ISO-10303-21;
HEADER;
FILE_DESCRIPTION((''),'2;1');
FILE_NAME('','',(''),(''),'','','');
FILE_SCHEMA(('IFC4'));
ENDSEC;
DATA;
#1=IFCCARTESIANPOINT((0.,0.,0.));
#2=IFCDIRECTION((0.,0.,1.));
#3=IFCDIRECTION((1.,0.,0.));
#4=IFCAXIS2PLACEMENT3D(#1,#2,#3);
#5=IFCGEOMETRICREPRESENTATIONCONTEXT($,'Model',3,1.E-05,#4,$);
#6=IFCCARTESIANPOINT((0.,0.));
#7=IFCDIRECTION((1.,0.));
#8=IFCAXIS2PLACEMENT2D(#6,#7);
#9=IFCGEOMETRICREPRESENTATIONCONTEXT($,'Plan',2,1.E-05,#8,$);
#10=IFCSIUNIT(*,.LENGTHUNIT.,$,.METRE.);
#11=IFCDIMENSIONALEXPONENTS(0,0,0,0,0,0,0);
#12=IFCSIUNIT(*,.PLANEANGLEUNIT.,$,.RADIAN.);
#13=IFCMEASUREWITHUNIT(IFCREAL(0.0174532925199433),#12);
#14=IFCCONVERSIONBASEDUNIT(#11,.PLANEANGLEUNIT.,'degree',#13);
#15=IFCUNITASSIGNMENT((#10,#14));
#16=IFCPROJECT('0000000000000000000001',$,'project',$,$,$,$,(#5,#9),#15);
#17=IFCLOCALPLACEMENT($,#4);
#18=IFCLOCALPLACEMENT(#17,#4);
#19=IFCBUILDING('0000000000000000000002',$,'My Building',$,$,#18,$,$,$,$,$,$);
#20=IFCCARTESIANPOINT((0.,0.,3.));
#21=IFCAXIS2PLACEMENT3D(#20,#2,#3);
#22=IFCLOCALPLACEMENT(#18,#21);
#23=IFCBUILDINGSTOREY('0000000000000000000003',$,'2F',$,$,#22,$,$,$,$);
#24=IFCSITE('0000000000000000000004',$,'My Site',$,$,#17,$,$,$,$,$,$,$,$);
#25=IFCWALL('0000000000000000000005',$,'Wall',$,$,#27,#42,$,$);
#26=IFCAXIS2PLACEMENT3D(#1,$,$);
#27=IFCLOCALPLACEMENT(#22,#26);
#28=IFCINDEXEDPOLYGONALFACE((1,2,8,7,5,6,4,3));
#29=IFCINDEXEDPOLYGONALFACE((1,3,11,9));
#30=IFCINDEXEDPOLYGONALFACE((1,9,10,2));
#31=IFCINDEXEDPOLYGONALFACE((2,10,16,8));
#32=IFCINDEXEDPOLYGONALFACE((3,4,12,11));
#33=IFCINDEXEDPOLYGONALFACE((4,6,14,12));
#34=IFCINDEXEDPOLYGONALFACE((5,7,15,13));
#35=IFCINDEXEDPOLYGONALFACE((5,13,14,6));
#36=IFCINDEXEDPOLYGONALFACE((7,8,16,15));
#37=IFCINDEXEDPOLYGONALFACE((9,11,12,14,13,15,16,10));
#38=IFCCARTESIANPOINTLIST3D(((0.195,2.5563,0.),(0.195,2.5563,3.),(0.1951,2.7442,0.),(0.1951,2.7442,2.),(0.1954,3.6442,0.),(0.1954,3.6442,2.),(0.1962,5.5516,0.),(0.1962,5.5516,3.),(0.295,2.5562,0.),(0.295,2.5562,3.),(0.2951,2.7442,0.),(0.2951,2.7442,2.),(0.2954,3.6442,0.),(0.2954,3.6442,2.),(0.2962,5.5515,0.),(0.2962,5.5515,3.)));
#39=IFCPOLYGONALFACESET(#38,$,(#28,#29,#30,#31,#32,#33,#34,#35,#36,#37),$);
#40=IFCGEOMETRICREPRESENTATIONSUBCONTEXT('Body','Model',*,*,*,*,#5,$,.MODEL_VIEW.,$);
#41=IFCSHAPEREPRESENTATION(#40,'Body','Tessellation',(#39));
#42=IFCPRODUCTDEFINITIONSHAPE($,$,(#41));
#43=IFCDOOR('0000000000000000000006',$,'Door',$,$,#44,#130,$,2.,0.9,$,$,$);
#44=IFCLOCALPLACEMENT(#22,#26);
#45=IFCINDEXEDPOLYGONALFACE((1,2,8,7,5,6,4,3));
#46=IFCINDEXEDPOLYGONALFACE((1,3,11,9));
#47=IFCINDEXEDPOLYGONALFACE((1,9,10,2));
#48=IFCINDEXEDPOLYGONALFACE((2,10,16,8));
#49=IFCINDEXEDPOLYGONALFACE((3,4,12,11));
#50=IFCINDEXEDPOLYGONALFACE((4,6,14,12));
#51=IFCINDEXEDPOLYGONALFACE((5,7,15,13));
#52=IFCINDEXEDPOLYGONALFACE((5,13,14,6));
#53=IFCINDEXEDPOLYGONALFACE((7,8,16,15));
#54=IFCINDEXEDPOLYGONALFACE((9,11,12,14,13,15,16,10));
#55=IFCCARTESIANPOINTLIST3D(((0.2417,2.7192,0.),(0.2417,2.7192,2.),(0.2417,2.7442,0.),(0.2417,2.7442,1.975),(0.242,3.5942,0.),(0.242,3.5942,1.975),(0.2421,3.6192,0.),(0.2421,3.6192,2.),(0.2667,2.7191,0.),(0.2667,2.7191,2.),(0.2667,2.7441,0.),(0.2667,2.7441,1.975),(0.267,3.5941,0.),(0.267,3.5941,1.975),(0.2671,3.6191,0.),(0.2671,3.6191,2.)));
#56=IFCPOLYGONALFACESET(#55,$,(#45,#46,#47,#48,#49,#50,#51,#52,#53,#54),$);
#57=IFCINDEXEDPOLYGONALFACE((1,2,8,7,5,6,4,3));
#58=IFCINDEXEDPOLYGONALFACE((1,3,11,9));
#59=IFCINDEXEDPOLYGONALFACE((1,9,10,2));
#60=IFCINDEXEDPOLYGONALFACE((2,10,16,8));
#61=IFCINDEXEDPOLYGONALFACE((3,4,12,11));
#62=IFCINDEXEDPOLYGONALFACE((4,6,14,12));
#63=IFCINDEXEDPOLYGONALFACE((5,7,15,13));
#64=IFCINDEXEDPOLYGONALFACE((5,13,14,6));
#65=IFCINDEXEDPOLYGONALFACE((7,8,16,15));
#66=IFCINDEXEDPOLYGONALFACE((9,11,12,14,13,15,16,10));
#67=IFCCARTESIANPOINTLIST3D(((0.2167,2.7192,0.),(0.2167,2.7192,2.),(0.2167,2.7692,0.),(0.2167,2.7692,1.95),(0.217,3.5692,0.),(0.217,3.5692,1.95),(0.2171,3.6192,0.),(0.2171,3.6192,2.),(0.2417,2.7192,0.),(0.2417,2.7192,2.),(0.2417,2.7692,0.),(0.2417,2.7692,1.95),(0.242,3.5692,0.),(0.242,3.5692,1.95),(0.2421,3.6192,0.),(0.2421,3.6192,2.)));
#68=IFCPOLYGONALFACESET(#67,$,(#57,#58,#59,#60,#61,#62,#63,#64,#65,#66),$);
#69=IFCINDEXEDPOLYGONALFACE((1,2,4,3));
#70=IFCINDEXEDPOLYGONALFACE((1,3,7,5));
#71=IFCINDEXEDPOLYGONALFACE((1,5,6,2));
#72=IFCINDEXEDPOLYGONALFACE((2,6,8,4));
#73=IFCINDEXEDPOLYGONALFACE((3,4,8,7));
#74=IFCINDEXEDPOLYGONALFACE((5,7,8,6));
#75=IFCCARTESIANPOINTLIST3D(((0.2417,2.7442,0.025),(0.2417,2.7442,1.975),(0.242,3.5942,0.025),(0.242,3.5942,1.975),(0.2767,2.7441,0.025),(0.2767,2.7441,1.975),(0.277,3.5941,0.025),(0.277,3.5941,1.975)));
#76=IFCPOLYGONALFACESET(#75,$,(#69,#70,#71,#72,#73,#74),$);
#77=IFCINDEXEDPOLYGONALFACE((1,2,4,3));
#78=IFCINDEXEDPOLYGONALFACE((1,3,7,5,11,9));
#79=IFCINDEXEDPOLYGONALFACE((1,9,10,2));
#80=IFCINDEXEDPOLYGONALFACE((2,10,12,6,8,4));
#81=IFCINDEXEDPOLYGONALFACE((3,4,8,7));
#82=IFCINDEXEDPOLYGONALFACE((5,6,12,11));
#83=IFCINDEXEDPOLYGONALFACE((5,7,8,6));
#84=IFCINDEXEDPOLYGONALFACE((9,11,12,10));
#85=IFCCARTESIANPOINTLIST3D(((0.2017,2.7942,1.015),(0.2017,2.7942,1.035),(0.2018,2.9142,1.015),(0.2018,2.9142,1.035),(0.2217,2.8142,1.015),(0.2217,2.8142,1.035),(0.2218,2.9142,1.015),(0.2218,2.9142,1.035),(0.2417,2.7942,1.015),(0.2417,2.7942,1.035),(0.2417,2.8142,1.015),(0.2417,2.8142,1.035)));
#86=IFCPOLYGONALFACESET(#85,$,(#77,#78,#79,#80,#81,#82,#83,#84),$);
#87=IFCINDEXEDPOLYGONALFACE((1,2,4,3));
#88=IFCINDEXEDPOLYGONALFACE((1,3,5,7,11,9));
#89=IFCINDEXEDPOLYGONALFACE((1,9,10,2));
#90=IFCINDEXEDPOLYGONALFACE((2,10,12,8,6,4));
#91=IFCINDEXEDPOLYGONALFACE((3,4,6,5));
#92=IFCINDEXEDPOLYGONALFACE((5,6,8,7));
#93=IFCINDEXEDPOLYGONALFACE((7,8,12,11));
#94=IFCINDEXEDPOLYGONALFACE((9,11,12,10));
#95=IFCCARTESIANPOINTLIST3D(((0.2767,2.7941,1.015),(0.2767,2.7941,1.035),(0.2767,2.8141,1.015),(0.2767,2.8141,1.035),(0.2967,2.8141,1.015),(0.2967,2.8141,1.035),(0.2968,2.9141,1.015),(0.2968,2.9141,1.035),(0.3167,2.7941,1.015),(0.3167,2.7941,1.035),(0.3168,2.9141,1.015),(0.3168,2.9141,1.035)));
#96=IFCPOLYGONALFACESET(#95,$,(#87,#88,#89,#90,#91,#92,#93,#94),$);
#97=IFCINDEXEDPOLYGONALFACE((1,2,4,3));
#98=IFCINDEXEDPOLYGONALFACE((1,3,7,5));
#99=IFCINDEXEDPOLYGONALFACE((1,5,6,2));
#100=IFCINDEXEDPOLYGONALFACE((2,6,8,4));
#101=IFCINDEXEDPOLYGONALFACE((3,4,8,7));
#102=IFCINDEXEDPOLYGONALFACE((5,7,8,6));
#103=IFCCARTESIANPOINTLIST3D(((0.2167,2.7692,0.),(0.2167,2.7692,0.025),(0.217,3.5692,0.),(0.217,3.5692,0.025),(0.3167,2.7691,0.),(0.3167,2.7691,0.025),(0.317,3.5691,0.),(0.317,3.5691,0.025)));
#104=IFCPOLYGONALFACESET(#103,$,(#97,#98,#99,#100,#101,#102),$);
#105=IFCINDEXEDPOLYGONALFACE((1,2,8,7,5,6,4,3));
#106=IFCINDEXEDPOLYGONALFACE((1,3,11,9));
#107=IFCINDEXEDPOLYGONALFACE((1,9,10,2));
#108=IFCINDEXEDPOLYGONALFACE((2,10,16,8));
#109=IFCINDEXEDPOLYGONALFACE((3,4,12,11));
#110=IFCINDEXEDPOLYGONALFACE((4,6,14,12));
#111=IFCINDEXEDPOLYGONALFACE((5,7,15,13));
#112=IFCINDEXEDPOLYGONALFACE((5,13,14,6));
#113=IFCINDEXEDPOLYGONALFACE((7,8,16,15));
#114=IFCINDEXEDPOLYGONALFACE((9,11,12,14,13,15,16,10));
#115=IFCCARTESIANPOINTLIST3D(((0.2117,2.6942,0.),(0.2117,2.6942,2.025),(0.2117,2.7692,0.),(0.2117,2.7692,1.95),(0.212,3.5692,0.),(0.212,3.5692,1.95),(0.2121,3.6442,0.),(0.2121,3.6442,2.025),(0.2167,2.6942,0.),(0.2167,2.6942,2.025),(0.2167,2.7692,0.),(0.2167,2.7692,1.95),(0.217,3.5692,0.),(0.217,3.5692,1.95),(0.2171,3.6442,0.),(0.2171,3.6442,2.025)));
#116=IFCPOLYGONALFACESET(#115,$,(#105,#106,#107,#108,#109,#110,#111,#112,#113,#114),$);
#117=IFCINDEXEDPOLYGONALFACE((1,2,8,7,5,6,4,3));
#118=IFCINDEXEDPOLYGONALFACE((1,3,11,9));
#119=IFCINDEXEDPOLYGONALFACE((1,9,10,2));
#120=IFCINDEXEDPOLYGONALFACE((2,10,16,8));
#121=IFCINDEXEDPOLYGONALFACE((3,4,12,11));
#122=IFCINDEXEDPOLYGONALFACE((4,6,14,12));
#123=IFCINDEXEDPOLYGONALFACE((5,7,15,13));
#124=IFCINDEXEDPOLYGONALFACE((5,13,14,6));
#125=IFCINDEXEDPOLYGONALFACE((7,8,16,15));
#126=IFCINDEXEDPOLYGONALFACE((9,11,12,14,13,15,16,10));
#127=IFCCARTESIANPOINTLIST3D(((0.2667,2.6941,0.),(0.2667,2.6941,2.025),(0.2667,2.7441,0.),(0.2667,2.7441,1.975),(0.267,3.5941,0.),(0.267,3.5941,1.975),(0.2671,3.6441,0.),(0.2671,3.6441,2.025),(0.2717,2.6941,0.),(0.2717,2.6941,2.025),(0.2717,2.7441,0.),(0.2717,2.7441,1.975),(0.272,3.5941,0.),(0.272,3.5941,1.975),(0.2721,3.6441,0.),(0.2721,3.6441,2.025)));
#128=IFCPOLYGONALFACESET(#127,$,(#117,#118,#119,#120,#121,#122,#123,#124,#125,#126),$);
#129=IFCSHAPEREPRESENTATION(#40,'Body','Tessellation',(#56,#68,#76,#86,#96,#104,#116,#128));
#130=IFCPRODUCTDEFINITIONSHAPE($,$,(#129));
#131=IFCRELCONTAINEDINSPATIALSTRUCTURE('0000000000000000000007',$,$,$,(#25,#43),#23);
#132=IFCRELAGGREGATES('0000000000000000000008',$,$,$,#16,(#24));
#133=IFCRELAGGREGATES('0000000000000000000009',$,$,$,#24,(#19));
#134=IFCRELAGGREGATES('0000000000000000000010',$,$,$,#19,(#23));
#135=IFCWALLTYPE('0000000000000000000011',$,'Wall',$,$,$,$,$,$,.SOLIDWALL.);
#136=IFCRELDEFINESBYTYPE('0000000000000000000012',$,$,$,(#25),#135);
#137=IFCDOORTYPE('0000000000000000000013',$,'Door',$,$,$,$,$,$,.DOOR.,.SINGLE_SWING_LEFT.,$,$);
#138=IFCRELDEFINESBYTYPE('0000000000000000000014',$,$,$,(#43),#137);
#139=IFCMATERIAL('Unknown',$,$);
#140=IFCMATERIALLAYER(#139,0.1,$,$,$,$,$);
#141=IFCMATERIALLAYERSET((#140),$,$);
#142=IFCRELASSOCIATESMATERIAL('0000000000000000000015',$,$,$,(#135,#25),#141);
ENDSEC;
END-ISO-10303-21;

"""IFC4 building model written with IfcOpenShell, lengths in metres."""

from ifc_helpers import new_model, entity, si_unit, converted_unit, frame, origin_with_axes, origin_2d_with_axis, place, context, subcontext, project, spatial, line, indexed_curve, outline, extrude, shape, source, transform, mapped, material, layer, layer_set, layer_usage, type_object, type_shapes, element, fill, save


model = new_model("IFC4")

# Units and contexts
model_context = context("Model", 3, precision=1e-05, world=origin_with_axes())
plan_context = context("Plan", 2, precision=1e-05, world=origin_2d_with_axis())
body_context_1 = subcontext(model_context, "Body", "Model", "MODEL_VIEW")
body_context_2 = subcontext(plan_context, "Body", "Plan", "PLAN_VIEW")
ifc_project = project(units=[si_unit("LENGTHUNIT", "METRE"), converted_unit("PLANEANGLEUNIT", "degree", entity("IfcReal", 0.0174532925199433), si_unit("PLANEANGLEUNIT", "RADIAN"), dimensions=[0, 0, 0, 0, 0, 0, 0])], contexts=[model_context, plan_context])

# Site, building, storey
site_placement = place(None, origin_with_axes())
site = spatial("IfcSite", under=ifc_project, at=site_placement, Name="My Site")
building_placement = place(site_placement, origin_with_axes())
building = spatial("IfcBuilding", under=site, at=building_placement, Name="My Building")
storey_placement = place(building_placement, frame((0.0, 0.0, 3.0), z_axis=(0.0, 0.0, 1.0), x_axis=(1.0, 0.0, 0.0)))
storey = spatial("IfcBuildingStorey", under=building, at=storey_placement, Name="2F")

# Shared definitions
ifc_material = material(Name="Unknown")
ifc_layer = layer(ifc_material, 0.1)
ifc_layer_set = layer_set([ifc_layer])
wall_type = type_object("IfcWallType", Name="Wall", PredefinedType="SOLIDWALL", material=ifc_layer_set)

# Wall, opening, door
ifc_layer_usage_1 = layer_usage(ifc_layer_set, "AXIS2", "POSITIVE", 0.0)
wall_1_placement = place(storey_placement, frame((0.1962, 5.5516, 0.0), z_axis=(0.0, 0.0, 1.0), x_axis=(-0.000399, -1.0, 0.0)))
wall_1 = element("IfcWall", 1, at=wall_1_placement, inside=storey, type_object=wall_type, material=ifc_layer_usage_1, Name="Wall", context=body_context_1, shape_type="SweptSolid", body=[
    extrude(outline(indexed_curve([(0.0, 0.0), (0.0, 0.1), (2.9953, 0.1), (2.9953, 0.0)], segments=[line(1, 2, 3, 4, 1)])), origin_with_axes(), (0.0, 0.0, 1.0), 3.0),
])
shared_shape_1 = source(origin_with_axes(), body_context_1, "Body", "SweptSolid", [
    extrude(outline(indexed_curve([(0.0, 0.0), (0.9, 0.0), (0.9, 2.0), (0.0, 2.0)], segments=[line(1, 2, 3, 4, 1)])), frame((0.0, -0.6, 0.0), z_axis=(0.0, -1.0, 0.0), x_axis=(1.0, 0.0, 0.0)), (0.0, 0.0, -1.0), 1.2),
])
opening_1_placement = place(wall_1_placement, frame((1.9074, 0.0, 0.0), z_axis=(0.0, 0.0, 1.0), x_axis=(1.0, 0.0, 0.0)))
opening_1 = element("IfcOpeningElement", 2, at=opening_1_placement, cuts=wall_1, PredefinedType="OPENING", context=body_context_1, shape_type="MappedRepresentation", body=[
    mapped(shared_shape_1, transform((0.0, 0.0, 0.0), x_axis=(1.0, 0.0, 0.0), y_axis=(0.0, 1.0, 0.0), z_axis=(0.0, 0.0, 1.0), scale=1.0)),
])
door_type_1 = type_object("IfcDoorType", Name="Door", OperationType="SINGLE_SWING_LEFT", PredefinedType="DOOR")
shared_shape_2 = source(origin_with_axes(), body_context_1, "Body", "SweptSolid", [
    extrude(outline(indexed_curve([(0.0, 0.0), (0.0, 2.0), (0.9, 2.0), (0.9, 0.0), (0.875, 0.0), (0.875, 1.975), (0.025, 1.975), (0.025, 0.0)], segments=[line(1, 2, 3, 4, 5, 6, 7, 8, 1)])), frame((0.0, 0.025, 0.0), z_axis=(0.0, -1.0, 0.0), x_axis=(1.0, 0.0, 0.0)), (0.0, 0.0, -1.0), 0.025),
    extrude(outline(indexed_curve([(0.0, 0.0), (0.0, 2.0), (0.9, 2.0), (0.9, 0.0), (0.85, 0.0), (0.85, 1.95), (0.05, 1.95), (0.05, 0.0)], segments=[line(1, 2, 3, 4, 5, 6, 7, 8, 1)])), frame((0.0, 0.0, 0.0), z_axis=(0.0, -1.0, 0.0), x_axis=(1.0, 0.0, 0.0)), (0.0, 0.0, -1.0), 0.025),
    extrude(outline(indexed_curve([(0.0, 0.0), (0.85, 0.0), (0.85, 0.035), (0.0, 0.035)], segments=[line(1, 2, 3, 4, 1)])), frame((0.025, 0.025, 0.025), z_axis=(0.0, 0.0, 1.0), x_axis=(1.0, 0.0, 0.0)), (0.0, 0.0, 1.0), 1.95),
    extrude(outline(indexed_curve([(0.0, 0.0), (0.0, -0.04), (-0.12, -0.04), (-0.12, -0.02), (-0.02, -0.02), (-0.02, 0.0)], segments=[line(1, 2, 3, 4, 5, 6, 1)])), frame((0.825, 0.025, 1.015), z_axis=(0.0, 0.0, 1.0), x_axis=(1.0, 0.0, 0.0)), (0.0, 0.0, 1.0), 0.02),
    extrude(outline(indexed_curve([(0.0, 0.0), (0.0, 0.04), (-0.12, 0.04), (-0.12, 0.02), (-0.02, 0.02), (-0.02, 0.0)], segments=[line(1, 2, 3, 4, 5, 6, 1)])), frame((0.825, 0.06, 1.015), z_axis=(0.0, 0.0, 1.0), x_axis=(1.0, 0.0, 0.0)), (0.0, 0.0, 1.0), 0.02),
    extrude(outline(indexed_curve([(0.0, 0.0), (0.8, 0.0), (0.8, 0.1), (0.0, 0.1)], segments=[line(1, 2, 3, 4, 1)])), frame((0.05, 0.0, 0.0), z_axis=(0.0, 0.0, 1.0), x_axis=(1.0, 0.0, 0.0)), (0.0, 0.0, 1.0), 0.025),
    extrude(outline(indexed_curve([(0.0, 0.0), (0.0, 2.025), (0.95, 2.025), (0.95, 0.0), (0.875, 0.0), (0.875, 1.95), (0.075, 1.95), (0.075, 0.0)], segments=[line(1, 2, 3, 4, 5, 6, 7, 8, 1)])), frame((-0.025, -0.005, 0.0), z_axis=(0.0, -1.0, 0.0), x_axis=(1.0, 0.0, 0.0)), (0.0, 0.0, -1.0), 0.005),
    extrude(outline(indexed_curve([(0.0, 0.0), (0.0, 2.025), (0.95, 2.025), (0.95, 0.0), (0.9, 0.0), (0.9, 1.975), (0.05, 1.975), (0.05, 0.0)], segments=[line(1, 2, 3, 4, 5, 6, 7, 8, 1)])), frame((-0.025, 0.05, 0.0), z_axis=(0.0, -1.0, 0.0), x_axis=(1.0, 0.0, 0.0)), (0.0, 0.0, -1.0), 0.005),
])
shared_shape_3 = source(origin_with_axes(), body_context_2, "Body", "Curve2D", [
    entity("IfcIndexedPolyCurve", entity("IfcCartesianPointList2D", [[0.0, 0.0], [0.0, 0.05], [0.025, 0.05], [0.025, 0.025], [0.05, 0.025], [0.05, 0.0]]), [entity("IfcLineIndex", [1, 2, 3, 4, 5, 6, 1])]),
    entity("IfcIndexedPolyCurve", entity("IfcCartesianPointList2D", [[0.9, 0.0], [0.9, 0.05], [0.875, 0.05], [0.875, 0.025], [0.85, 0.025], [0.85, 0.0]]), [entity("IfcLineIndex", [1, 2, 3, 4, 5, 6, 1])]),
    entity("IfcTrimmedCurve", entity("IfcEllipse", entity("IfcAxis2Placement2D", entity("IfcCartesianPoint", [0.06, 0.05]), entity("IfcDirection", [1.0, 0.0])), 0.815, 0.85), [entity("IfcCartesianPoint", [0.875, 0.05])], [entity("IfcCartesianPoint", [0.06, 0.9])], True, "CARTESIAN"),
    entity("IfcIndexedPolyCurve", entity("IfcCartesianPointList2D", [[0.025, 0.05], [0.06, 0.05], [0.06, 0.9], [0.025, 0.9]]), [entity("IfcLineIndex", [1, 2, 3, 4, 1])]),
])
type_shapes(door_type_1, [shared_shape_2, shared_shape_3])
door_1_placement = place(opening_1_placement, frame((0.025, 0.0216, 0.0), z_axis=(0.0, 0.0, 1.0), x_axis=(1.0, 0.0, 0.0)))
door_1 = element("IfcDoor", 3, at=door_1_placement, inside=storey, type_object=door_type_1, Name="Door", OverallHeight=2.0, OverallWidth=0.9, shapes=[
    shape(body_context_1, "Body", "MappedRepresentation", [mapped(shared_shape_2, transform((0.0, 0.0, 0.0), x_axis=(1.0, 0.0, 0.0), y_axis=(0.0, 1.0, 0.0), z_axis=(0.0, 0.0, 1.0), scale=1.0))]),
    shape(body_context_2, "Body", "MappedRepresentation", [mapped(shared_shape_3, transform((0.0, 0.0, 0.0), x_axis=(1.0, 0.0, 0.0), y_axis=(0.0, 1.0, 0.0), z_axis=(0.0, 0.0, 1.0), scale=1.0))]),
])
fill(opening_1, door_1)

save(model, "model.ifc")
